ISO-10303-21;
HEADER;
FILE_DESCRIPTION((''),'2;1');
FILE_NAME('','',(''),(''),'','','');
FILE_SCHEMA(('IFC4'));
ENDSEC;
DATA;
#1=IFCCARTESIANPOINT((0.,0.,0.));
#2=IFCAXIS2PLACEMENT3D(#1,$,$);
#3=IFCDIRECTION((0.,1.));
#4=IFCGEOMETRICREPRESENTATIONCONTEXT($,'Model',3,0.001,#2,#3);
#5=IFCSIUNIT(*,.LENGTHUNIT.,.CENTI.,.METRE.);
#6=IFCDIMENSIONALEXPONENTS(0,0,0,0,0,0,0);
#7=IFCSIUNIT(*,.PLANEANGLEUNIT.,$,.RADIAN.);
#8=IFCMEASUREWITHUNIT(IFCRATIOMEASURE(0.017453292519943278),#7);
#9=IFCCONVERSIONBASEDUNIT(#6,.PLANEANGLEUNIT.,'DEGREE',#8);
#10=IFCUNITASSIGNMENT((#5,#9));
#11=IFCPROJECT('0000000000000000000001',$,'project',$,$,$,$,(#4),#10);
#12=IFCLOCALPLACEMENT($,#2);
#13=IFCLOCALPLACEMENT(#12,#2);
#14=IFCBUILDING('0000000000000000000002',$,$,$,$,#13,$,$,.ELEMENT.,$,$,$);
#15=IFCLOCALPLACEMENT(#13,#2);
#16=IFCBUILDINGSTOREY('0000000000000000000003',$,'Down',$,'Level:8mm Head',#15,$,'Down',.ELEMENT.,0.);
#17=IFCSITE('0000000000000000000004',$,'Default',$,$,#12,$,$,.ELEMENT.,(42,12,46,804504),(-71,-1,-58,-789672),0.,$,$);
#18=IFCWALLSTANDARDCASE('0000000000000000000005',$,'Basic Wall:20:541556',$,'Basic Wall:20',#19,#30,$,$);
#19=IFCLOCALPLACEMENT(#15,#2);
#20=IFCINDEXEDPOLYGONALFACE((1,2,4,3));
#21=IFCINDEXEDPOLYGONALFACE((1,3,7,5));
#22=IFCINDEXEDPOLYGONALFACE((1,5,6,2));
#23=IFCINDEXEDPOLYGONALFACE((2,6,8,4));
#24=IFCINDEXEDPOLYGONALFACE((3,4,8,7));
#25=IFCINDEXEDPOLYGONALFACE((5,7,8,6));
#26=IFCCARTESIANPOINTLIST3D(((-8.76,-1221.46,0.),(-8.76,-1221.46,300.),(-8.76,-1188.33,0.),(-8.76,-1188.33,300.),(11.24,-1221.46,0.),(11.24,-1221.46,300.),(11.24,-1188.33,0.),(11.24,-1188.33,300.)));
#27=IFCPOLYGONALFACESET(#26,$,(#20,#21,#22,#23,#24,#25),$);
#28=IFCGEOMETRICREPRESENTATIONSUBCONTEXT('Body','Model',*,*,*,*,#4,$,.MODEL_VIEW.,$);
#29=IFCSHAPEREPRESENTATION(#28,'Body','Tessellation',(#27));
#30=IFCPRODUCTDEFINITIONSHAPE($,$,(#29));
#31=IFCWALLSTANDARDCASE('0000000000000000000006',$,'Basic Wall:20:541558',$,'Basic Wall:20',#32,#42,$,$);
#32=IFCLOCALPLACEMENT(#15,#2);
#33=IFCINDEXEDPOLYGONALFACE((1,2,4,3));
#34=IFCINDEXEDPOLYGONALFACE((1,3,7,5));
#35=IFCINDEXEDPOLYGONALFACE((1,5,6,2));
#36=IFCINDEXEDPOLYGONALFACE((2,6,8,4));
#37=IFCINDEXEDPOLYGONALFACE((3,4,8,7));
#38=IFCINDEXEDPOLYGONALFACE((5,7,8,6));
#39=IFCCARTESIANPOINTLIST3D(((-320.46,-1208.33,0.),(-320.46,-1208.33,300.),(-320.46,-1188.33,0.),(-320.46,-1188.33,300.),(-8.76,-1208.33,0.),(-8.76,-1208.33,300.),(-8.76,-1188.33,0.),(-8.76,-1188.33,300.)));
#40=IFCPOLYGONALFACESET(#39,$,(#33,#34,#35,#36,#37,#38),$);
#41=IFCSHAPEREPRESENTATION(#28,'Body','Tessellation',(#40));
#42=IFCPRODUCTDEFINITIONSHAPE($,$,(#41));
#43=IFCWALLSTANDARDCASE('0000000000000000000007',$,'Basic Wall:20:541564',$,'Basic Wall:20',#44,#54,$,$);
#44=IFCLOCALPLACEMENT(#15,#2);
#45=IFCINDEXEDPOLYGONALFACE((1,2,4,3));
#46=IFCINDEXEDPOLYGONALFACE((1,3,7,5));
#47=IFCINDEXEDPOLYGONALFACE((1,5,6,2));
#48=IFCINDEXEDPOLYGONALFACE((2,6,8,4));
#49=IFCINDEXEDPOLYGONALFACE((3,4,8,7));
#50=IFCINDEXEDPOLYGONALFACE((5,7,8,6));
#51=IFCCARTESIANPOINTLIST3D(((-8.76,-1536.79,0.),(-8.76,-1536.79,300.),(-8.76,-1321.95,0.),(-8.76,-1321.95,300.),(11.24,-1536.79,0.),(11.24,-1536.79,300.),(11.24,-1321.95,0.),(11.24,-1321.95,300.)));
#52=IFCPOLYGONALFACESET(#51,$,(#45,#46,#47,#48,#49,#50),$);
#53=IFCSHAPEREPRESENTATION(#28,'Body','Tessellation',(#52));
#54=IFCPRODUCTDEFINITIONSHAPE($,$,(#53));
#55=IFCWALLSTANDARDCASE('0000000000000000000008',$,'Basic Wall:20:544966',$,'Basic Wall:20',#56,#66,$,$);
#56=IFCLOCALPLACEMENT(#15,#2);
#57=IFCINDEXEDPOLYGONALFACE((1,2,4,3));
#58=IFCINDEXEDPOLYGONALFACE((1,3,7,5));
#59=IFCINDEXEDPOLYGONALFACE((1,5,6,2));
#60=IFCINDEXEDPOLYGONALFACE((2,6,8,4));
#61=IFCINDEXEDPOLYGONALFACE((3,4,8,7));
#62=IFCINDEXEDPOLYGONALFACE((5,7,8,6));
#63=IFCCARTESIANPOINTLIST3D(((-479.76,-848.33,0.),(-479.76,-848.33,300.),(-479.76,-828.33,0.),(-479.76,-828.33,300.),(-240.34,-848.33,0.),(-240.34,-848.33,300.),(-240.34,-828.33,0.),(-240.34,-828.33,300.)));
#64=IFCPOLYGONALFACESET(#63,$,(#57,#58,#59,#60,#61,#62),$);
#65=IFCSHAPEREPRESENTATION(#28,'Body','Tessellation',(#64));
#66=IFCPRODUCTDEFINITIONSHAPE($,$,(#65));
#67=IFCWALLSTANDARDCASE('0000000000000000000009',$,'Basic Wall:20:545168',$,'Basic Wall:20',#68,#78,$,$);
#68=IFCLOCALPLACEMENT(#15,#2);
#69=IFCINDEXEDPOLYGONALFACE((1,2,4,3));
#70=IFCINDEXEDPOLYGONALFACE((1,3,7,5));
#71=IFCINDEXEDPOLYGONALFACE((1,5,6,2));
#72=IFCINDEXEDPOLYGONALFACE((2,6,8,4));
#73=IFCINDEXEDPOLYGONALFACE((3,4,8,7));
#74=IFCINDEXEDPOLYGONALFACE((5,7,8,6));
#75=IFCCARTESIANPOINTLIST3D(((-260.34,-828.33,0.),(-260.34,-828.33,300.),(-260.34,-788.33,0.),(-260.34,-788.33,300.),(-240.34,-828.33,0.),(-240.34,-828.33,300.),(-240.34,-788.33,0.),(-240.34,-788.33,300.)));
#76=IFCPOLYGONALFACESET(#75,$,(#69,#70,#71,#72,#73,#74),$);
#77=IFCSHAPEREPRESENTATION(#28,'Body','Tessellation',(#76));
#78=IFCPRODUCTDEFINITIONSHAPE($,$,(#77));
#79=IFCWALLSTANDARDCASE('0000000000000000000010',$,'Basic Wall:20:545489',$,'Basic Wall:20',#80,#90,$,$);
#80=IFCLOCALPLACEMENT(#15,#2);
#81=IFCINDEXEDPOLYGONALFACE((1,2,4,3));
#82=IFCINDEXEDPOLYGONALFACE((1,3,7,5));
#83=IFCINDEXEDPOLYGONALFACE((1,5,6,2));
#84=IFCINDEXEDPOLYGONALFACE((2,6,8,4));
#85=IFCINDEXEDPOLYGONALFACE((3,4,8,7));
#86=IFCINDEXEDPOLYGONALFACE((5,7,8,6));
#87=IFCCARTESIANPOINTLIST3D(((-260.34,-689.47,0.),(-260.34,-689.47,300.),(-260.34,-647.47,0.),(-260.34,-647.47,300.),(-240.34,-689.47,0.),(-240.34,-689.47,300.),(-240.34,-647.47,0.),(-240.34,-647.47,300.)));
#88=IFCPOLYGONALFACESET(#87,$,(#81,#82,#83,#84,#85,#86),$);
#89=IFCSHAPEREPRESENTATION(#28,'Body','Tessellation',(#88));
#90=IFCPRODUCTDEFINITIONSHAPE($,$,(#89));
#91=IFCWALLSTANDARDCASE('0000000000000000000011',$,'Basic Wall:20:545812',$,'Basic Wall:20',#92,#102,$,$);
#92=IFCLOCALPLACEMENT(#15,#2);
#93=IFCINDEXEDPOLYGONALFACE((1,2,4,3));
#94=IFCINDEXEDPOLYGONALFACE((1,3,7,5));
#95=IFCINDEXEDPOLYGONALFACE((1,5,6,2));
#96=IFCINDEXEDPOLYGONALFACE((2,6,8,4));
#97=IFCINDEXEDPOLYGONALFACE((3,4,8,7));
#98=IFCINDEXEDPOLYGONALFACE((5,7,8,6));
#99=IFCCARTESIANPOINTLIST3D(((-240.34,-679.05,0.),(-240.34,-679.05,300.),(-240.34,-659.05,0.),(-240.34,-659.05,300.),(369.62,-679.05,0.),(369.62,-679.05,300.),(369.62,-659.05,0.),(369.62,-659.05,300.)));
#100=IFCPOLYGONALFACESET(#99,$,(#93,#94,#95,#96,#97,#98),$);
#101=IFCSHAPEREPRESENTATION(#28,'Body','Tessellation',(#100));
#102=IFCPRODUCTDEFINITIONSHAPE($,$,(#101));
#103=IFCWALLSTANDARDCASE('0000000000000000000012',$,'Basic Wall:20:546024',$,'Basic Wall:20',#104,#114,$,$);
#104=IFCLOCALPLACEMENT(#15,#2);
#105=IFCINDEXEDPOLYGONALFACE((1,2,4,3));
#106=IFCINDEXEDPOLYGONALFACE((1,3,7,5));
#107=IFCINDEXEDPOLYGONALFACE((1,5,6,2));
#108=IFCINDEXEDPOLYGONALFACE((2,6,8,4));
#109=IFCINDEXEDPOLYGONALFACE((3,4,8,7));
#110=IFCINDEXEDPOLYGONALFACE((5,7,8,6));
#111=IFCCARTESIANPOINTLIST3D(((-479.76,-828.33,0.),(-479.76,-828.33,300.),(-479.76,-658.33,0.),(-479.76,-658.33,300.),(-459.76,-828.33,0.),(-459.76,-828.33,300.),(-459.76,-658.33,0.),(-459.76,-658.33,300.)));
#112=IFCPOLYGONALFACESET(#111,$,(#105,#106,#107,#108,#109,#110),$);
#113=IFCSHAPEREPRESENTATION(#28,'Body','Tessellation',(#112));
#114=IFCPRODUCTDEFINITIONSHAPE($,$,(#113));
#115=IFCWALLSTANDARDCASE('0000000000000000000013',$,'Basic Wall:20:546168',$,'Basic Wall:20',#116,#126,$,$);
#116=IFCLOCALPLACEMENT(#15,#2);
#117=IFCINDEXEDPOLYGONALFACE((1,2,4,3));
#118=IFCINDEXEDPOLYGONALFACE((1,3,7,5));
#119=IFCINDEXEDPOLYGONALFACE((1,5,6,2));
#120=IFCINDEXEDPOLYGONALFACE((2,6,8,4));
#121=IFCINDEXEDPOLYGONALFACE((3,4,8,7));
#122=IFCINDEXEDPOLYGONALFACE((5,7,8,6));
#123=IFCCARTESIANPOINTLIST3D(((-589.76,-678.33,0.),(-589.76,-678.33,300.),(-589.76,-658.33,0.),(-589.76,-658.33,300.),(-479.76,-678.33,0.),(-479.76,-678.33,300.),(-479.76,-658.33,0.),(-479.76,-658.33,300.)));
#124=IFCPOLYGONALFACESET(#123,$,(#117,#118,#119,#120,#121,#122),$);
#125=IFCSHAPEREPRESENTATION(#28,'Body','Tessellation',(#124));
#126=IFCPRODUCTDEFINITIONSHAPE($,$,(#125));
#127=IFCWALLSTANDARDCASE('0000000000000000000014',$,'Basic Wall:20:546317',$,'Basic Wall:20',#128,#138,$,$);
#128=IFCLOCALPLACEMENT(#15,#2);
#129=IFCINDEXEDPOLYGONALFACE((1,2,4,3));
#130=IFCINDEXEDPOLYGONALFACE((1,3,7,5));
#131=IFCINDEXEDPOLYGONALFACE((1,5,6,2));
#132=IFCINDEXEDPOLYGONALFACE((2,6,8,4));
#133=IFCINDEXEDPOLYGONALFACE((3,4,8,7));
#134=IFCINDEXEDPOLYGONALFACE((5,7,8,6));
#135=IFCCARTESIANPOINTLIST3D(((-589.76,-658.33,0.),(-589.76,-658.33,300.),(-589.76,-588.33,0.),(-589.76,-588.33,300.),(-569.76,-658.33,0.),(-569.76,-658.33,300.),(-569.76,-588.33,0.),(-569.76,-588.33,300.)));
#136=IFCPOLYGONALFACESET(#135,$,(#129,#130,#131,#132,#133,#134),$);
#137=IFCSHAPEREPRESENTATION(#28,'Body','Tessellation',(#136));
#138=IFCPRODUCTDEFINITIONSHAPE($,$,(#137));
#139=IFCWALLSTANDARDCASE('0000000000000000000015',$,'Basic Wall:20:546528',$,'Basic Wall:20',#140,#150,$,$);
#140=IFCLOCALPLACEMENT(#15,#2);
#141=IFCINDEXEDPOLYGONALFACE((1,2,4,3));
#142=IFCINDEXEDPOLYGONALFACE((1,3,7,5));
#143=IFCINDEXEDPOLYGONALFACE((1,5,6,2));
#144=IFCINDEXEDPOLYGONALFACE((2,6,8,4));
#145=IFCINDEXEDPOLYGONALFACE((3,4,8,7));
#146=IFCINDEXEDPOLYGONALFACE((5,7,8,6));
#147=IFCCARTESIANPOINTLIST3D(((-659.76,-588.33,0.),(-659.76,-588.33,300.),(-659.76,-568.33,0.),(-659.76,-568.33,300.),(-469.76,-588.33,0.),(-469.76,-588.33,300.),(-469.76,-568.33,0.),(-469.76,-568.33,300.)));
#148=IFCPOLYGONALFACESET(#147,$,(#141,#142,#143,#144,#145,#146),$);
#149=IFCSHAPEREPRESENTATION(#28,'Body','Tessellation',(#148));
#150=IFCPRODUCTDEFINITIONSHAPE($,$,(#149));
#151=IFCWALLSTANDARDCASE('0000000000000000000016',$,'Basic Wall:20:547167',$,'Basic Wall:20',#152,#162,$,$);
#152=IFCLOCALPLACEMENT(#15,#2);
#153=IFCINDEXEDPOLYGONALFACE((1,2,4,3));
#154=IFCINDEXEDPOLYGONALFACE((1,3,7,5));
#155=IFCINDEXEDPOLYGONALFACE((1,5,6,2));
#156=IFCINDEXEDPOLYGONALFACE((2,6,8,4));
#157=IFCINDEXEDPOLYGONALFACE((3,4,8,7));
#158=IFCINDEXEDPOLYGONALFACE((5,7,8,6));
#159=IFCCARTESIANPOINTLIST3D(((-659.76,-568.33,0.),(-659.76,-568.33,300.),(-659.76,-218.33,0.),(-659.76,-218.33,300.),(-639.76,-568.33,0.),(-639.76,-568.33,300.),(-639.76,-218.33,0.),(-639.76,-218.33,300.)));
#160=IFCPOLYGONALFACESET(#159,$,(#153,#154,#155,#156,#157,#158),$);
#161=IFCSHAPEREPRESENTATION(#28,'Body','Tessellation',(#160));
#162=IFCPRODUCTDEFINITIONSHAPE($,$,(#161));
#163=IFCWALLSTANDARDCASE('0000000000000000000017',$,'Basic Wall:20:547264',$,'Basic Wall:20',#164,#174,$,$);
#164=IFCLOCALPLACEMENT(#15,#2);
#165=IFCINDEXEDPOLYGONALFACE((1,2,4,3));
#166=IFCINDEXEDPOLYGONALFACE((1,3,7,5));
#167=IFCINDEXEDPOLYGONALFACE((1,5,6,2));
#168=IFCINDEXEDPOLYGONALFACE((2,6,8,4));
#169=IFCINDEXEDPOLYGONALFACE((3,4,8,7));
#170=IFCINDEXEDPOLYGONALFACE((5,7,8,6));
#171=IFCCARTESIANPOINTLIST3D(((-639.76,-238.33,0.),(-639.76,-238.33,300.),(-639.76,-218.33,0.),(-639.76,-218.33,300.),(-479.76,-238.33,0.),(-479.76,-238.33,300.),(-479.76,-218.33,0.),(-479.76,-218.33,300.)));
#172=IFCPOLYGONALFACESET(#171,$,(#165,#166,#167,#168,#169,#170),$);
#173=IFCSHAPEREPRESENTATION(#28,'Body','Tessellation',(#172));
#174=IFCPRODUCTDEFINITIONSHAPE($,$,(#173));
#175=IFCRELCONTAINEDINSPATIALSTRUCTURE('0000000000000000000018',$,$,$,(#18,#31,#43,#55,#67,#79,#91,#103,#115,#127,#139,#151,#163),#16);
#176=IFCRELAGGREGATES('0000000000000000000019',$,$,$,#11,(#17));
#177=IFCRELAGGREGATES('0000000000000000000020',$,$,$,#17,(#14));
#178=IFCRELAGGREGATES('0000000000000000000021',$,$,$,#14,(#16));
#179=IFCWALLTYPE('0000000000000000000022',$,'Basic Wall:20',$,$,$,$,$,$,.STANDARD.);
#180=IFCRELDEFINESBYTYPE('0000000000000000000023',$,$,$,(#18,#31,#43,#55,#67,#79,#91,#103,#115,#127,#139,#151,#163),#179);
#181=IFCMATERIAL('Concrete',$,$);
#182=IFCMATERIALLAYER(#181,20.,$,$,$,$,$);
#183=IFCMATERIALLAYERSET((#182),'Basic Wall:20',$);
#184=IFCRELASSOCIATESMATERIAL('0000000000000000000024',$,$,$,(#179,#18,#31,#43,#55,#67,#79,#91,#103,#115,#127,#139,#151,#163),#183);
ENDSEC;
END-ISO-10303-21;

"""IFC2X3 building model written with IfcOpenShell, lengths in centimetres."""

from ifc_helpers import new_model, entity, si_unit, converted_unit, direction, frame, frame_2d, origin, place, context, subcontext, project, spatial, rectangle, extrude, material, layer, layer_set, layer_usage, type_object, element, save


model = new_model("IFC2X3")

# Units and contexts
model_context = context("Model", 3, precision=0.001, world=origin(), true_north=direction((0.0, 1.0)))
body_context = subcontext(model_context, "Body", "Model", "MODEL_VIEW")
ifc_project = project(units=[si_unit("LENGTHUNIT", "METRE", prefix="CENTI"), converted_unit("PLANEANGLEUNIT", "DEGREE", entity("IfcRatioMeasure", 0.017453292519943278), si_unit("PLANEANGLEUNIT", "RADIAN"), dimensions=[0, 0, 0, 0, 0, 0, 0])], contexts=[model_context])

# Site, building, storey
site_placement = place(None, origin())
site = spatial("IfcSite", under=ifc_project, at=site_placement, Name="Default", CompositionType="ELEMENT", RefLatitude=(42, 12, 46, 804504), RefLongitude=(-71, -1, -58, -789672), RefElevation=0.0)
building_placement = place(site_placement, origin())
building = spatial("IfcBuilding", under=site, at=building_placement, CompositionType="ELEMENT")
storey_placement = place(building_placement, origin())
storey = spatial("IfcBuildingStorey", under=building, at=storey_placement, Name="Down", ObjectType="Level:8mm Head", LongName="Down", CompositionType="ELEMENT", Elevation=0.0)

# Shared definitions
ifc_material = material(Name="Concrete")

# Walls
ifc_layer_1 = layer(ifc_material, 20.0)
ifc_layer_set_1 = layer_set([ifc_layer_1], Name="Basic Wall:20")
wall_type_1 = type_object("IfcWallType", Name="Basic Wall:20", PredefinedType="STANDARD", material=ifc_layer_set_1)
ifc_layer_usage_1 = layer_usage(ifc_layer_set_1, "AXIS2", "POSITIVE", -10.0)
wall_1_placement = place(storey_placement, frame((1.24, -1221.46, 0.0), z_axis=(0.0, 0.0, 1.0), x_axis=(0.0, 1.0, 0.0)))
element("IfcWallStandardCase", 1, at=wall_1_placement, inside=storey, type_object=wall_type_1, material=ifc_layer_usage_1, Name="Basic Wall:20:541556", ObjectType="Basic Wall:20", context=body_context, shape_type="SweptSolid", body=[
    extrude(rectangle(XDim=33.13, YDim=20.0, at=frame_2d((16.56, 0.0), x_axis=(-1.0, 0.0))), origin(), (0.0, 0.0, 1.0), 300.0),
])
ifc_layer_usage_2 = layer_usage(ifc_layer_set_1, "AXIS2", "POSITIVE", -10.0)
wall_2_placement = place(storey_placement, frame((-8.76, -1198.33, 0.0), z_axis=(0.0, 0.0, 1.0), x_axis=(-1.0, 0.0, 0.0)))
element("IfcWallStandardCase", 2, at=wall_2_placement, inside=storey, type_object=wall_type_1, material=ifc_layer_usage_2, Name="Basic Wall:20:541558", ObjectType="Basic Wall:20", context=body_context, shape_type="SweptSolid", body=[
    extrude(rectangle(XDim=311.7, YDim=20.0, at=frame_2d((155.85, 0.0), x_axis=(-1.0, 0.0))), origin(), (0.0, 0.0, 1.0), 300.0),
])
ifc_layer_usage_3 = layer_usage(ifc_layer_set_1, "AXIS2", "POSITIVE", -10.0)
wall_3_placement = place(storey_placement, frame((1.24, -1536.79, 0.0), z_axis=(0.0, 0.0, 1.0), x_axis=(0.0, 1.0, 0.0)))
element("IfcWallStandardCase", 3, at=wall_3_placement, inside=storey, type_object=wall_type_1, material=ifc_layer_usage_3, Name="Basic Wall:20:541564", ObjectType="Basic Wall:20", context=body_context, shape_type="SweptSolid", body=[
    extrude(rectangle(XDim=214.85, YDim=20.0, at=frame_2d((107.42, 0.0), x_axis=(-1.0, 0.0))), origin(), (0.0, 0.0, 1.0), 300.0),
])
ifc_layer_usage_4 = layer_usage(ifc_layer_set_1, "AXIS2", "POSITIVE", -10.0)
wall_4_placement = place(storey_placement, frame((-479.76, -838.33, 0.0)))
element("IfcWallStandardCase", 4, at=wall_4_placement, inside=storey, type_object=wall_type_1, material=ifc_layer_usage_4, Name="Basic Wall:20:544966", ObjectType="Basic Wall:20", context=body_context, shape_type="SweptSolid", body=[
    extrude(rectangle(XDim=239.43, YDim=20.0, at=frame_2d((119.71, 0.0), x_axis=(-1.0, 0.0))), origin(), (0.0, 0.0, 1.0), 300.0),
])
ifc_layer_usage_5 = layer_usage(ifc_layer_set_1, "AXIS2", "POSITIVE", -10.0)
wall_5_placement = place(storey_placement, frame((-250.34, -828.33, 0.0), z_axis=(0.0, 0.0, 1.0), x_axis=(0.0, 1.0, 0.0)))
element("IfcWallStandardCase", 5, at=wall_5_placement, inside=storey, type_object=wall_type_1, material=ifc_layer_usage_5, Name="Basic Wall:20:545168", ObjectType="Basic Wall:20", context=body_context, shape_type="SweptSolid", body=[
    extrude(rectangle(XDim=40.0, YDim=20.0, at=frame_2d((20.0, 0.0), x_axis=(-1.0, 0.0))), origin(), (0.0, 0.0, 1.0), 300.0),
])
ifc_layer_usage_6 = layer_usage(ifc_layer_set_1, "AXIS2", "POSITIVE", -10.0)
wall_6_placement = place(storey_placement, frame((-250.34, -689.47, 0.0), z_axis=(0.0, 0.0, 1.0), x_axis=(0.0, 1.0, 0.0)))
element("IfcWallStandardCase", 6, at=wall_6_placement, inside=storey, type_object=wall_type_1, material=ifc_layer_usage_6, Name="Basic Wall:20:545489", ObjectType="Basic Wall:20", context=body_context, shape_type="SweptSolid", body=[
    extrude(rectangle(XDim=42.0, YDim=20.0, at=frame_2d((21.0, 0.0), x_axis=(-1.0, 0.0))), origin(), (0.0, 0.0, 1.0), 300.0),
])
ifc_layer_usage_7 = layer_usage(ifc_layer_set_1, "AXIS2", "POSITIVE", -10.0)
wall_7_placement = place(storey_placement, frame((-240.34, -669.05, 0.0)))
element("IfcWallStandardCase", 7, at=wall_7_placement, inside=storey, type_object=wall_type_1, material=ifc_layer_usage_7, Name="Basic Wall:20:545812", ObjectType="Basic Wall:20", context=body_context, shape_type="SweptSolid", body=[
    extrude(rectangle(XDim=609.95, YDim=20.0, at=frame_2d((304.98, 0.0), x_axis=(-1.0, 0.0))), origin(), (0.0, 0.0, 1.0), 300.0),
])
ifc_layer_usage_8 = layer_usage(ifc_layer_set_1, "AXIS2", "NEGATIVE", 10.0)
wall_8_placement = place(storey_placement, frame((-469.76, -828.33, 0.0), z_axis=(0.0, 0.0, 1.0), x_axis=(0.0, 1.0, 0.0)))
element("IfcWallStandardCase", 8, at=wall_8_placement, inside=storey, type_object=wall_type_1, material=ifc_layer_usage_8, Name="Basic Wall:20:546024", ObjectType="Basic Wall:20", context=body_context, shape_type="SweptSolid", body=[
    extrude(rectangle(XDim=170.0, YDim=20.0, at=frame_2d((85.0, 0.0), x_axis=(-1.0, 0.0))), origin(), (0.0, 0.0, 1.0), 300.0),
])
ifc_layer_usage_9 = layer_usage(ifc_layer_set_1, "AXIS2", "POSITIVE", -10.0)
wall_9_placement = place(storey_placement, frame((-479.76, -668.33, 0.0), z_axis=(0.0, 0.0, 1.0), x_axis=(-1.0, 0.0, 0.0)))
element("IfcWallStandardCase", 9, at=wall_9_placement, inside=storey, type_object=wall_type_1, material=ifc_layer_usage_9, Name="Basic Wall:20:546168", ObjectType="Basic Wall:20", context=body_context, shape_type="SweptSolid", body=[
    extrude(rectangle(XDim=110.0, YDim=20.0, at=frame_2d((55.0, 0.0), x_axis=(-1.0, 0.0))), origin(), (0.0, 0.0, 1.0), 300.0),
])
ifc_layer_usage_10 = layer_usage(ifc_layer_set_1, "AXIS2", "NEGATIVE", 10.0)
wall_10_placement = place(storey_placement, frame((-579.76, -658.33, 0.0), z_axis=(0.0, 0.0, 1.0), x_axis=(0.0, 1.0, 0.0)))
element("IfcWallStandardCase", 10, at=wall_10_placement, inside=storey, type_object=wall_type_1, material=ifc_layer_usage_10, Name="Basic Wall:20:546317", ObjectType="Basic Wall:20", context=body_context, shape_type="SweptSolid", body=[
    extrude(rectangle(XDim=70.0, YDim=20.0, at=frame_2d((35.0, 0.0), x_axis=(-1.0, 0.0))), origin(), (0.0, 0.0, 1.0), 300.0),
])
ifc_layer_usage_11 = layer_usage(ifc_layer_set_1, "AXIS2", "NEGATIVE", 10.0)
wall_11_placement = place(storey_placement, frame((-469.76, -578.33, 0.0), z_axis=(0.0, 0.0, 1.0), x_axis=(-1.0, 0.0, 0.0)))
element("IfcWallStandardCase", 11, at=wall_11_placement, inside=storey, type_object=wall_type_1, material=ifc_layer_usage_11, Name="Basic Wall:20:546528", ObjectType="Basic Wall:20", context=body_context, shape_type="SweptSolid", body=[
    extrude(rectangle(XDim=190.0, YDim=20.0, at=frame_2d((95.0, 0.0), x_axis=(-1.0, 0.0))), origin(), (0.0, 0.0, 1.0), 300.0),
])
ifc_layer_usage_12 = layer_usage(ifc_layer_set_1, "AXIS2", "NEGATIVE", 10.0)
wall_12_placement = place(storey_placement, frame((-649.76, -568.33, 0.0), z_axis=(0.0, 0.0, 1.0), x_axis=(0.0, 1.0, 0.0)))
element("IfcWallStandardCase", 12, at=wall_12_placement, inside=storey, type_object=wall_type_1, material=ifc_layer_usage_12, Name="Basic Wall:20:547167", ObjectType="Basic Wall:20", context=body_context, shape_type="SweptSolid", body=[
    extrude(rectangle(XDim=350.0, YDim=20.0, at=frame_2d((175.0, 0.0), x_axis=(-1.0, 0.0))), origin(), (0.0, 0.0, 1.0), 300.0),
])
ifc_layer_usage_13 = layer_usage(ifc_layer_set_1, "AXIS2", "NEGATIVE", 10.0)
wall_13_placement = place(storey_placement, frame((-639.76, -228.33, 0.0)))
element("IfcWallStandardCase", 13, at=wall_13_placement, inside=storey, type_object=wall_type_1, material=ifc_layer_usage_13, Name="Basic Wall:20:547264", ObjectType="Basic Wall:20", context=body_context, shape_type="SweptSolid", body=[
    extrude(rectangle(XDim=160.0, YDim=20.0, at=frame_2d((80.0, 0.0), x_axis=(-1.0, 0.0))), origin(), (0.0, 0.0, 1.0), 300.0),
])

save(model, "model.ifc")
